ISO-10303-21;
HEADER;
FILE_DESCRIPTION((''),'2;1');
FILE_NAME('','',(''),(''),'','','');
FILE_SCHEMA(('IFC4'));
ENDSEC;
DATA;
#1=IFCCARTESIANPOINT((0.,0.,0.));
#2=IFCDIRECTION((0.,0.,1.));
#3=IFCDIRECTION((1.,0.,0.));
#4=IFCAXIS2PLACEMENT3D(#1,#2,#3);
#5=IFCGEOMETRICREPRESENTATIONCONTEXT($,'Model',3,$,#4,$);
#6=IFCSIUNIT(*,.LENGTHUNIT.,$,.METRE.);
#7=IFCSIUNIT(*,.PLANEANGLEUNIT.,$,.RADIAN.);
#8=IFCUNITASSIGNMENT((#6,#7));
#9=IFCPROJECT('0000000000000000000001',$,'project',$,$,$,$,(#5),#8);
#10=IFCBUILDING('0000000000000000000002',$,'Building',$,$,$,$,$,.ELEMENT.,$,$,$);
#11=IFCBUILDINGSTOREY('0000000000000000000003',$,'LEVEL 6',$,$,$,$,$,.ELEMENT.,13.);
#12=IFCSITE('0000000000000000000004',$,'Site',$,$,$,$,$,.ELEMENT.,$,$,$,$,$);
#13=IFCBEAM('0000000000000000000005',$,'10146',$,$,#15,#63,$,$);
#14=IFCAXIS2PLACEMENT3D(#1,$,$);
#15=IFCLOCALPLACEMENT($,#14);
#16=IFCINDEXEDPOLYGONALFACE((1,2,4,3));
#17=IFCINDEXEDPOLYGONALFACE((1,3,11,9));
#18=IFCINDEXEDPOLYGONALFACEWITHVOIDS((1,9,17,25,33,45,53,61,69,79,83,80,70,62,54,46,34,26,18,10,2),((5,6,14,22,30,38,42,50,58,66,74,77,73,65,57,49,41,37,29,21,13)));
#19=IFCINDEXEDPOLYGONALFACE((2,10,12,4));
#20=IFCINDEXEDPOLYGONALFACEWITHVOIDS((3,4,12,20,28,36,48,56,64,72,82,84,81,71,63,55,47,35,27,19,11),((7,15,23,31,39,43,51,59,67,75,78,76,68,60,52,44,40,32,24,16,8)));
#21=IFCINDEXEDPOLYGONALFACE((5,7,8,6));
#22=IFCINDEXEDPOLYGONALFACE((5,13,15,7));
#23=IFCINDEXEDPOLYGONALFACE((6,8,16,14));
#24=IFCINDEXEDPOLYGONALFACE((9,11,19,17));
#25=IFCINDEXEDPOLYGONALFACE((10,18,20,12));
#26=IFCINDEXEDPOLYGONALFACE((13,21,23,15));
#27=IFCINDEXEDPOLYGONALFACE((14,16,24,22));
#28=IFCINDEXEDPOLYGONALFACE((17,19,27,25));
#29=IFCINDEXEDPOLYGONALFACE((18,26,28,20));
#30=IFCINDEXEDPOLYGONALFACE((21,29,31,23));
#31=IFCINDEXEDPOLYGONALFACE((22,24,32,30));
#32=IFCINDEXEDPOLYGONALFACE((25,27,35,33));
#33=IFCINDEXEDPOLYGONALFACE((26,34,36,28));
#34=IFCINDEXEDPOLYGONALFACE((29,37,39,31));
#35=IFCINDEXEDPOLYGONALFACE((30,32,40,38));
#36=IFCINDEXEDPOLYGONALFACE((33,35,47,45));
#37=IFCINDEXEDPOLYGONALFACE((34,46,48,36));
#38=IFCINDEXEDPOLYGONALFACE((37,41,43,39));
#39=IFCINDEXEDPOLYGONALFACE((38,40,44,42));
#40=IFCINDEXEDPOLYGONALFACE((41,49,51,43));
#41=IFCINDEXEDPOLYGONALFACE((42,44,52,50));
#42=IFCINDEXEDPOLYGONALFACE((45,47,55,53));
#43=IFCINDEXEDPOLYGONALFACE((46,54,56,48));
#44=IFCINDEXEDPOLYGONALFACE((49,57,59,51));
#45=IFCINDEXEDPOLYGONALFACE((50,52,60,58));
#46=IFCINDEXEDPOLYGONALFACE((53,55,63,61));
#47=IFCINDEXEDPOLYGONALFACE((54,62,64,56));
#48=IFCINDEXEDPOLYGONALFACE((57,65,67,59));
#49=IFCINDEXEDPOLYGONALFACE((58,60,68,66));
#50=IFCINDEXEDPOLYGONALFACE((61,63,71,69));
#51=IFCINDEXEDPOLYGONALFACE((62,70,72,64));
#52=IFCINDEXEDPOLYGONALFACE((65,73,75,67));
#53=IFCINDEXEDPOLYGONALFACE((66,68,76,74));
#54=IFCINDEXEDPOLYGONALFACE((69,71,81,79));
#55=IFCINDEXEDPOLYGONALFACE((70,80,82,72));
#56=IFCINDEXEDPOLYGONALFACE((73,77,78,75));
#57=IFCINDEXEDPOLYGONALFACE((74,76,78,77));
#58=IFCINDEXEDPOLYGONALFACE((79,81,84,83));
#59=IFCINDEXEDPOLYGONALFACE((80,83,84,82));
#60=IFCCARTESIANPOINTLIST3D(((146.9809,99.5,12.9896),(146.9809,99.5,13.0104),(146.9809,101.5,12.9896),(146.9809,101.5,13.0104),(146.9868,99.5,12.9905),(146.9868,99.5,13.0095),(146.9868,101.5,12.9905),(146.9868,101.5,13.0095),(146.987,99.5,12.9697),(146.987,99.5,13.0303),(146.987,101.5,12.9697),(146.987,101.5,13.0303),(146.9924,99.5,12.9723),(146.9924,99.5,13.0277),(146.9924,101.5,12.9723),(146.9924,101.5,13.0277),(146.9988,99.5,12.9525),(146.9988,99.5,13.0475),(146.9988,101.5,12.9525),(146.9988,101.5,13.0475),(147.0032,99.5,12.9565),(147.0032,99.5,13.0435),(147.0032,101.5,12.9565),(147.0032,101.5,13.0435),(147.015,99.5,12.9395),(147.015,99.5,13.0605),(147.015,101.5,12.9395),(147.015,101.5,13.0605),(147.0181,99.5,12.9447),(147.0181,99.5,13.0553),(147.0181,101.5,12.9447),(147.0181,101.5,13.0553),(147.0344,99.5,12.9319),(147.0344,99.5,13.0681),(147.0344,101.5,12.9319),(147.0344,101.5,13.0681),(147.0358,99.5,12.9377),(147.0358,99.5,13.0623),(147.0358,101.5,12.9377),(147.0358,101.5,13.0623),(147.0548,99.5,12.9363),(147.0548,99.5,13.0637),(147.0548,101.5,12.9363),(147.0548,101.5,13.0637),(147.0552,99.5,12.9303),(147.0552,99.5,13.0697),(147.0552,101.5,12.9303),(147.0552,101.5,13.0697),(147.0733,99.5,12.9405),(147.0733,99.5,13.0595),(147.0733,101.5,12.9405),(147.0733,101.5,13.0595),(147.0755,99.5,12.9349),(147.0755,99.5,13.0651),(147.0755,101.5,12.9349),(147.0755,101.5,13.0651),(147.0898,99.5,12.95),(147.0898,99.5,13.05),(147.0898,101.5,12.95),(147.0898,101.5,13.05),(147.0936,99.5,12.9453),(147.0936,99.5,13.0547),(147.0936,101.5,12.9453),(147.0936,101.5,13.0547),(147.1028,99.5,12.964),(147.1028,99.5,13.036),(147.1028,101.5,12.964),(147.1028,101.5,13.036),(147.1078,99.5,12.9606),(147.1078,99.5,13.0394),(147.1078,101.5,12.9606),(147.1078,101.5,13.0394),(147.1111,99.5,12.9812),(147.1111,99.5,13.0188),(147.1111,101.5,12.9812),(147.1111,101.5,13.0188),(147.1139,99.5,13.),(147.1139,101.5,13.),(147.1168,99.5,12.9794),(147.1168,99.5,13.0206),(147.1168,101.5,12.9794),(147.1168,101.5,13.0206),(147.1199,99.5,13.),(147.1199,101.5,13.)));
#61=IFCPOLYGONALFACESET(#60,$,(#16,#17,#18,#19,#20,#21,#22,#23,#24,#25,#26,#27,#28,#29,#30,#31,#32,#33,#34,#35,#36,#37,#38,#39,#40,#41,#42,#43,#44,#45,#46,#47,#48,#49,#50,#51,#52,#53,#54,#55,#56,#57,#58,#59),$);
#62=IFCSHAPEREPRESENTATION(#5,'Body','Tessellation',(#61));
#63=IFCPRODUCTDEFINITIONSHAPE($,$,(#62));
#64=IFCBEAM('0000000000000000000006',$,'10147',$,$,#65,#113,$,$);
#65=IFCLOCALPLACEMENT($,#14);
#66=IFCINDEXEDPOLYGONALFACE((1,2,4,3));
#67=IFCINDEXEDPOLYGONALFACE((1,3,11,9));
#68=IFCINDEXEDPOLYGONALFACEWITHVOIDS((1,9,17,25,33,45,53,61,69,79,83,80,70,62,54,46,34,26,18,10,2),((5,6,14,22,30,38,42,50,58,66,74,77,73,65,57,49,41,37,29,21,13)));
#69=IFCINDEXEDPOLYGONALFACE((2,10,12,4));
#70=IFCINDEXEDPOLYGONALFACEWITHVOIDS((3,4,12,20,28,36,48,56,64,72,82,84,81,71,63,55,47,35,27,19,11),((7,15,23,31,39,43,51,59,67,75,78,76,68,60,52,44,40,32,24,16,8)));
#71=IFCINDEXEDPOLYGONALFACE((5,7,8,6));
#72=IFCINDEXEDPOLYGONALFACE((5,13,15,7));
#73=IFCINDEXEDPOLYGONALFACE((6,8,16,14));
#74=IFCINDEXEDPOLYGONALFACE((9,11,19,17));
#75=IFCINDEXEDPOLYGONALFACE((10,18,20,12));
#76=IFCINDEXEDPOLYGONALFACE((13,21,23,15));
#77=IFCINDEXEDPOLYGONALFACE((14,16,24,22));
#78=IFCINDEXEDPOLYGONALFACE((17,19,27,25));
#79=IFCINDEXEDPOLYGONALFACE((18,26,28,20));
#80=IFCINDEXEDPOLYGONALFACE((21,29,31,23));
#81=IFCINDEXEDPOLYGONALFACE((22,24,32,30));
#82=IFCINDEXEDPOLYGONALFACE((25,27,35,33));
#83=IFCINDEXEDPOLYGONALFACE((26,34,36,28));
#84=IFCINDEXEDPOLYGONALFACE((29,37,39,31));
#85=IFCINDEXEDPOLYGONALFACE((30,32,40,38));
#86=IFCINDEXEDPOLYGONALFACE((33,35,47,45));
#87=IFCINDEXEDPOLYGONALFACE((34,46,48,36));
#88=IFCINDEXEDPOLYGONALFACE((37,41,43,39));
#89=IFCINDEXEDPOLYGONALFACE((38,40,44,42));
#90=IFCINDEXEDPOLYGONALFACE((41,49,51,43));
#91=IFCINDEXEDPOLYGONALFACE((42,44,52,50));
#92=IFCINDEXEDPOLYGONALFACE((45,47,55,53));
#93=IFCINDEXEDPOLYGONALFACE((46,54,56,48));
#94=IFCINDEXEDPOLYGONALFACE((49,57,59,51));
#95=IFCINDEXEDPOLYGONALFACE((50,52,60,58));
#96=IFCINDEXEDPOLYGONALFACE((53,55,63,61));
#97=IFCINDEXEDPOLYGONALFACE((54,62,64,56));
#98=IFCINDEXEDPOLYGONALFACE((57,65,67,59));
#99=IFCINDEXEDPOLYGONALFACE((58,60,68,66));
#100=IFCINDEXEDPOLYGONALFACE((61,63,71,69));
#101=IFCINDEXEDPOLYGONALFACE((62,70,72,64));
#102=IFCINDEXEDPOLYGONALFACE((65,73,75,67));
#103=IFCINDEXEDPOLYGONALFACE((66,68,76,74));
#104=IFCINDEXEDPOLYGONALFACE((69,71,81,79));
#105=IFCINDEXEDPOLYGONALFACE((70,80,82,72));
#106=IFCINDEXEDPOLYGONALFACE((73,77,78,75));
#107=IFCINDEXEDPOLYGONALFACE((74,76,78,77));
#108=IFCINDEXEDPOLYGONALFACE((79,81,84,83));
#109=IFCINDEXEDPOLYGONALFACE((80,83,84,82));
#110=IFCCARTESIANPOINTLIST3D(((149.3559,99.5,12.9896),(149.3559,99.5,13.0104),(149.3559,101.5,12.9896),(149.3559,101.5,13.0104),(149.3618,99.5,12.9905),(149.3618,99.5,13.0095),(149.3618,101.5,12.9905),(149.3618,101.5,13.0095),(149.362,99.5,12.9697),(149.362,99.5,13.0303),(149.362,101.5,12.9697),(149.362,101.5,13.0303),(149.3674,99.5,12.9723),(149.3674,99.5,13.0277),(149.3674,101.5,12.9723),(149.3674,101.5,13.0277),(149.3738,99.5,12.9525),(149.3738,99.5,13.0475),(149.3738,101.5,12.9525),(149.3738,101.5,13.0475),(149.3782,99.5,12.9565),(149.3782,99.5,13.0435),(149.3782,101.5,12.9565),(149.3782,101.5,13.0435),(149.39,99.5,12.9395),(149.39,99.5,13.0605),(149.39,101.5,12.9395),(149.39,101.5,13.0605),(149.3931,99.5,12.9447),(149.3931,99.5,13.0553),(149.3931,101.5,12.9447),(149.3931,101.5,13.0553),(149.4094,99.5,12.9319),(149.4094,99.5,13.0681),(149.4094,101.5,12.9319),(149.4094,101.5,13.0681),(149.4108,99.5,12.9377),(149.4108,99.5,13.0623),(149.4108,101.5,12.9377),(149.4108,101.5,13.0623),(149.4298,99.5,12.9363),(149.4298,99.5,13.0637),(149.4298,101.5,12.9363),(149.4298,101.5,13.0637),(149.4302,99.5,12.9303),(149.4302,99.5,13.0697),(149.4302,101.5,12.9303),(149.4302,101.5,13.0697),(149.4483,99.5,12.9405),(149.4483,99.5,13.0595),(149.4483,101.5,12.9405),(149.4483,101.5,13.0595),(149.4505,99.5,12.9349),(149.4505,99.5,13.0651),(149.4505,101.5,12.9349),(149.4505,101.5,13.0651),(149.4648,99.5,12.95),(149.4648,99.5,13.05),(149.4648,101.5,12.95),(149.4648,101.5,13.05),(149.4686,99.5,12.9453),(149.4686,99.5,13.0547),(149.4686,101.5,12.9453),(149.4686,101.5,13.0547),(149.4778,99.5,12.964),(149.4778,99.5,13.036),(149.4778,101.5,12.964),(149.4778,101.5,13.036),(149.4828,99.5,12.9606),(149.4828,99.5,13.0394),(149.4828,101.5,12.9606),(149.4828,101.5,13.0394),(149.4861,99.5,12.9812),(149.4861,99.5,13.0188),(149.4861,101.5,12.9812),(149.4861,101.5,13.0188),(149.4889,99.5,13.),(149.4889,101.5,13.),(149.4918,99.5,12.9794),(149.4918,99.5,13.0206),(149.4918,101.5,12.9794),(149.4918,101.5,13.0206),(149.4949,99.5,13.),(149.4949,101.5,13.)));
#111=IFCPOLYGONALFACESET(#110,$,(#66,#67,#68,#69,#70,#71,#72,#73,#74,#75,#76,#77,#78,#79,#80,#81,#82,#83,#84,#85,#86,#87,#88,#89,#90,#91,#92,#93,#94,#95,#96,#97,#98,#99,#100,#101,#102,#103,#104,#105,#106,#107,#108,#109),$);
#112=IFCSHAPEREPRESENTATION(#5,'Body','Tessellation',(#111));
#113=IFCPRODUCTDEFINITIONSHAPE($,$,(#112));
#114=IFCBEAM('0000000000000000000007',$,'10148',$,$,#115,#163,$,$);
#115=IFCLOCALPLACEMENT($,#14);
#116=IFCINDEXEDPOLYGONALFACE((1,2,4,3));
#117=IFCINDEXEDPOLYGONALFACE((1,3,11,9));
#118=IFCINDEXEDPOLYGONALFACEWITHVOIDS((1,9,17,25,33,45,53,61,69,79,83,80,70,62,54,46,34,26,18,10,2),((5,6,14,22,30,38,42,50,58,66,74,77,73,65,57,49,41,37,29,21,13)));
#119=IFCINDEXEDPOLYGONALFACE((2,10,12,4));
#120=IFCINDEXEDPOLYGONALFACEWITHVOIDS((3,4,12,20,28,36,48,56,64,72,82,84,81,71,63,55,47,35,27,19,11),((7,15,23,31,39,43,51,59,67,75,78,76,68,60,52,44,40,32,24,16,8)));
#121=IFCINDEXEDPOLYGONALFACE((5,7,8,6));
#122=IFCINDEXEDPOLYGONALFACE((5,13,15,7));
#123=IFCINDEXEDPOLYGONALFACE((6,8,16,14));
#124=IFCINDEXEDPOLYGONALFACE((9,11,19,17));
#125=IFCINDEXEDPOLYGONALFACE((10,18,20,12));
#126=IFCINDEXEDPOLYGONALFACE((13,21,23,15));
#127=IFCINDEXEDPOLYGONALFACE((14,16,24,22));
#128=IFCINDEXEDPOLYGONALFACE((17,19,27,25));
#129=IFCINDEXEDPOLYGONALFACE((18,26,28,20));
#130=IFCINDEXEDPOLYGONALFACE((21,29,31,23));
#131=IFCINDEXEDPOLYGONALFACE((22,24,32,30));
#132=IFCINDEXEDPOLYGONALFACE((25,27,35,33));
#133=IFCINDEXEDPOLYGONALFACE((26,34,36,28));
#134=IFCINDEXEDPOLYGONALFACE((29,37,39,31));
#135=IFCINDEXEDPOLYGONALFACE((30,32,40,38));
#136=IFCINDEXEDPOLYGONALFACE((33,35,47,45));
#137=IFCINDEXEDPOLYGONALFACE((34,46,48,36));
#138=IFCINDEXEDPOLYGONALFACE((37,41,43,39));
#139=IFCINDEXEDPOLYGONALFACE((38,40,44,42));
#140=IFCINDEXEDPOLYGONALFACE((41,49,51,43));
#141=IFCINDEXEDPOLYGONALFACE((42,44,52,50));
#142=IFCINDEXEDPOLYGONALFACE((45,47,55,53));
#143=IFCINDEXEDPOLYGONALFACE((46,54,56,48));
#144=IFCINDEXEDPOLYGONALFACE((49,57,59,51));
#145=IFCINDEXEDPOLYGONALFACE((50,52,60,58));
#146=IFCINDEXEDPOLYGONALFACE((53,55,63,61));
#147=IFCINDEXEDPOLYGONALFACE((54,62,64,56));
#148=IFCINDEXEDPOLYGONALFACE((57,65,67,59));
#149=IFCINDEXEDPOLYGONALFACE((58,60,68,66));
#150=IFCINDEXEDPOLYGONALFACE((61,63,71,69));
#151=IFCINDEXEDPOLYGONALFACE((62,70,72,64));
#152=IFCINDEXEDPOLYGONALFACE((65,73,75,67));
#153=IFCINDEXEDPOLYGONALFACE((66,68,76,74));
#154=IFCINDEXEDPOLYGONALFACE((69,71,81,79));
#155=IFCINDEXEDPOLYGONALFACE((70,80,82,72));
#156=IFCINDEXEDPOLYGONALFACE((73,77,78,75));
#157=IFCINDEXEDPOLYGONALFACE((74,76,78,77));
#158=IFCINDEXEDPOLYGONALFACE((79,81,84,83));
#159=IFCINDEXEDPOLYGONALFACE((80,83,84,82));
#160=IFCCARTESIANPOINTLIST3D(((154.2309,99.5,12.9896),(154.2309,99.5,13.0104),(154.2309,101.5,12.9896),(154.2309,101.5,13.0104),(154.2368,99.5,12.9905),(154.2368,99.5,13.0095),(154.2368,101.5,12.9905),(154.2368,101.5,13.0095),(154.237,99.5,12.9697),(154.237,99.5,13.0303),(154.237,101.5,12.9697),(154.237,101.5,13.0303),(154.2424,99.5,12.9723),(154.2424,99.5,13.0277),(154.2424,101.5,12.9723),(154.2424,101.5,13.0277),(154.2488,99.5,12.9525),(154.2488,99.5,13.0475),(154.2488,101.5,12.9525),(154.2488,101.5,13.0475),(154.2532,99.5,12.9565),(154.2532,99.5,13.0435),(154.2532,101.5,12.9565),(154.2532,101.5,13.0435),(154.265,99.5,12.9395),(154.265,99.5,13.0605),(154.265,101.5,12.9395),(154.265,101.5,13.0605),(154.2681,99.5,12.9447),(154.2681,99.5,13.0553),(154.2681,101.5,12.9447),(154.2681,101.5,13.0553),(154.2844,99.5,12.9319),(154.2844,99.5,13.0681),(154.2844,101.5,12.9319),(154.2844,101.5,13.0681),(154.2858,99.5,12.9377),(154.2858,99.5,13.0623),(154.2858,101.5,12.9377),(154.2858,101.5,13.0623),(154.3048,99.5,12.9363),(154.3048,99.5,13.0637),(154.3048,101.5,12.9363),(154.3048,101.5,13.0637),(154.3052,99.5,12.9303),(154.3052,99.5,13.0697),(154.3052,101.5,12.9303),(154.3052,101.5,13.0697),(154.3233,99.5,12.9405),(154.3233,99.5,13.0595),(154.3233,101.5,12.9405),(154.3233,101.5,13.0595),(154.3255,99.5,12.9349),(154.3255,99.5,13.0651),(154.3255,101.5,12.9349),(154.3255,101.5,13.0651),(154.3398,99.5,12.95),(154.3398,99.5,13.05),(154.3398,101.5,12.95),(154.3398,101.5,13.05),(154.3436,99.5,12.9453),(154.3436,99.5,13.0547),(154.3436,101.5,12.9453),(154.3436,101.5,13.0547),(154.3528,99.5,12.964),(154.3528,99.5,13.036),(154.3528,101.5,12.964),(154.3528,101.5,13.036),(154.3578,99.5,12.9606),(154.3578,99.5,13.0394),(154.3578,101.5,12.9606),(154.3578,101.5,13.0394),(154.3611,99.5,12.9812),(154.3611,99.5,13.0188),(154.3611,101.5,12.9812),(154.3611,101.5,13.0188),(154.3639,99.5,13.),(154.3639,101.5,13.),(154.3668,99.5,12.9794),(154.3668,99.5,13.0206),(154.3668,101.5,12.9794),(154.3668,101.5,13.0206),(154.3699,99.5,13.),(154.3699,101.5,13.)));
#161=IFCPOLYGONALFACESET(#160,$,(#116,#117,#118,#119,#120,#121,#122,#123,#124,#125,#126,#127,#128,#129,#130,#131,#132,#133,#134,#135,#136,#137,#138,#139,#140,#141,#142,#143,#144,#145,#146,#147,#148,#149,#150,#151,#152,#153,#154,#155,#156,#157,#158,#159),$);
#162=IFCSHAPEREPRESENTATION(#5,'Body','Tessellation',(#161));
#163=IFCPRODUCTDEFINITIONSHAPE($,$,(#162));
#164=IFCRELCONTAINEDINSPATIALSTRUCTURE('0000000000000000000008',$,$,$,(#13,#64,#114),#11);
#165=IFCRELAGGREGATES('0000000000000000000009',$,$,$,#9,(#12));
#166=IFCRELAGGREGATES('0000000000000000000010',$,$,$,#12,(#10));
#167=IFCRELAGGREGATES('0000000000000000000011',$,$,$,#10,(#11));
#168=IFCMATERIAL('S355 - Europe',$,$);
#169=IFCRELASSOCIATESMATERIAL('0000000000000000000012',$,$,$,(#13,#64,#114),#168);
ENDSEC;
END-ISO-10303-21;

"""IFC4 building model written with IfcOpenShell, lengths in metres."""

from ifc_helpers import new_model, si_unit, frame, origin_with_axes, origin_2d_with_axis, place, context, project, spatial, hollow_circle, extrude, material, material_profile, profile_set, profile_usage, element, save


model = new_model("IFC4")

# Units and contexts
model_context = context("Model", 3, world=origin_with_axes())
ifc_project = project(units=[si_unit("LENGTHUNIT", "METRE"), si_unit("PLANEANGLEUNIT", "RADIAN")], contexts=[model_context])

# Site, building, storey
site = spatial("IfcSite", under=ifc_project, Name="Site", CompositionType="ELEMENT")
building = spatial("IfcBuilding", under=site, Name="Building", CompositionType="ELEMENT")
storey = spatial("IfcBuildingStorey", under=building, Name="LEVEL 6", CompositionType="ELEMENT", Elevation=13.0)

# Shared definitions
ifc_material = material(Name="S355 - Europe")

# Beams
ifc_material_profile_1 = material_profile(ifc_material, hollow_circle(Radius=0.0699, WallThickness=0.006, at=origin_2d_with_axis()))
ifc_profile_set_1 = profile_set([ifc_material_profile_1])
ifc_profile_usage_1 = profile_usage(ifc_profile_set_1, cardinal=10)
beam_1_placement = place(None, frame((147.05, 101.5, 13.0), z_axis=(0.0, -1.0, 0.0), x_axis=(1.0, 0.0, 0.0)))
element("IfcBeam", 1, at=beam_1_placement, inside=storey, material=ifc_profile_usage_1, Name="10146", context=model_context, shape_type="SweptSolid", body=[
    extrude(hollow_circle(Radius=0.0699, WallThickness=0.006, at=origin_2d_with_axis()), origin_with_axes(), (0.0, 0.0, 1.0), 2.0),
])
ifc_material_profile_2 = material_profile(ifc_material, hollow_circle(Radius=0.0699, WallThickness=0.006, at=origin_2d_with_axis()))
ifc_profile_set_2 = profile_set([ifc_material_profile_2])
ifc_profile_usage_2 = profile_usage(ifc_profile_set_2, cardinal=10)
beam_2_placement = place(None, frame((149.425, 101.5, 13.0), z_axis=(0.0, -1.0, 0.0), x_axis=(1.0, 0.0, 0.0)))
element("IfcBeam", 2, at=beam_2_placement, inside=storey, material=ifc_profile_usage_2, Name="10147", context=model_context, shape_type="SweptSolid", body=[
    extrude(hollow_circle(Radius=0.0699, WallThickness=0.006, at=origin_2d_with_axis()), origin_with_axes(), (0.0, 0.0, 1.0), 2.0),
])
ifc_material_profile_3 = material_profile(ifc_material, hollow_circle(Radius=0.0699, WallThickness=0.006, at=origin_2d_with_axis()))
ifc_profile_set_3 = profile_set([ifc_material_profile_3])
ifc_profile_usage_3 = profile_usage(ifc_profile_set_3, cardinal=10)
beam_3_placement = place(None, frame((154.3, 101.5, 13.0), z_axis=(0.0, -1.0, 0.0), x_axis=(1.0, 0.0, 0.0)))
element("IfcBeam", 3, at=beam_3_placement, inside=storey, material=ifc_profile_usage_3, Name="10148", context=model_context, shape_type="SweptSolid", body=[
    extrude(hollow_circle(Radius=0.0699, WallThickness=0.006, at=origin_2d_with_axis()), origin_with_axes(), (0.0, 0.0, 1.0), 2.0),
])

save(model, "model.ifc")
